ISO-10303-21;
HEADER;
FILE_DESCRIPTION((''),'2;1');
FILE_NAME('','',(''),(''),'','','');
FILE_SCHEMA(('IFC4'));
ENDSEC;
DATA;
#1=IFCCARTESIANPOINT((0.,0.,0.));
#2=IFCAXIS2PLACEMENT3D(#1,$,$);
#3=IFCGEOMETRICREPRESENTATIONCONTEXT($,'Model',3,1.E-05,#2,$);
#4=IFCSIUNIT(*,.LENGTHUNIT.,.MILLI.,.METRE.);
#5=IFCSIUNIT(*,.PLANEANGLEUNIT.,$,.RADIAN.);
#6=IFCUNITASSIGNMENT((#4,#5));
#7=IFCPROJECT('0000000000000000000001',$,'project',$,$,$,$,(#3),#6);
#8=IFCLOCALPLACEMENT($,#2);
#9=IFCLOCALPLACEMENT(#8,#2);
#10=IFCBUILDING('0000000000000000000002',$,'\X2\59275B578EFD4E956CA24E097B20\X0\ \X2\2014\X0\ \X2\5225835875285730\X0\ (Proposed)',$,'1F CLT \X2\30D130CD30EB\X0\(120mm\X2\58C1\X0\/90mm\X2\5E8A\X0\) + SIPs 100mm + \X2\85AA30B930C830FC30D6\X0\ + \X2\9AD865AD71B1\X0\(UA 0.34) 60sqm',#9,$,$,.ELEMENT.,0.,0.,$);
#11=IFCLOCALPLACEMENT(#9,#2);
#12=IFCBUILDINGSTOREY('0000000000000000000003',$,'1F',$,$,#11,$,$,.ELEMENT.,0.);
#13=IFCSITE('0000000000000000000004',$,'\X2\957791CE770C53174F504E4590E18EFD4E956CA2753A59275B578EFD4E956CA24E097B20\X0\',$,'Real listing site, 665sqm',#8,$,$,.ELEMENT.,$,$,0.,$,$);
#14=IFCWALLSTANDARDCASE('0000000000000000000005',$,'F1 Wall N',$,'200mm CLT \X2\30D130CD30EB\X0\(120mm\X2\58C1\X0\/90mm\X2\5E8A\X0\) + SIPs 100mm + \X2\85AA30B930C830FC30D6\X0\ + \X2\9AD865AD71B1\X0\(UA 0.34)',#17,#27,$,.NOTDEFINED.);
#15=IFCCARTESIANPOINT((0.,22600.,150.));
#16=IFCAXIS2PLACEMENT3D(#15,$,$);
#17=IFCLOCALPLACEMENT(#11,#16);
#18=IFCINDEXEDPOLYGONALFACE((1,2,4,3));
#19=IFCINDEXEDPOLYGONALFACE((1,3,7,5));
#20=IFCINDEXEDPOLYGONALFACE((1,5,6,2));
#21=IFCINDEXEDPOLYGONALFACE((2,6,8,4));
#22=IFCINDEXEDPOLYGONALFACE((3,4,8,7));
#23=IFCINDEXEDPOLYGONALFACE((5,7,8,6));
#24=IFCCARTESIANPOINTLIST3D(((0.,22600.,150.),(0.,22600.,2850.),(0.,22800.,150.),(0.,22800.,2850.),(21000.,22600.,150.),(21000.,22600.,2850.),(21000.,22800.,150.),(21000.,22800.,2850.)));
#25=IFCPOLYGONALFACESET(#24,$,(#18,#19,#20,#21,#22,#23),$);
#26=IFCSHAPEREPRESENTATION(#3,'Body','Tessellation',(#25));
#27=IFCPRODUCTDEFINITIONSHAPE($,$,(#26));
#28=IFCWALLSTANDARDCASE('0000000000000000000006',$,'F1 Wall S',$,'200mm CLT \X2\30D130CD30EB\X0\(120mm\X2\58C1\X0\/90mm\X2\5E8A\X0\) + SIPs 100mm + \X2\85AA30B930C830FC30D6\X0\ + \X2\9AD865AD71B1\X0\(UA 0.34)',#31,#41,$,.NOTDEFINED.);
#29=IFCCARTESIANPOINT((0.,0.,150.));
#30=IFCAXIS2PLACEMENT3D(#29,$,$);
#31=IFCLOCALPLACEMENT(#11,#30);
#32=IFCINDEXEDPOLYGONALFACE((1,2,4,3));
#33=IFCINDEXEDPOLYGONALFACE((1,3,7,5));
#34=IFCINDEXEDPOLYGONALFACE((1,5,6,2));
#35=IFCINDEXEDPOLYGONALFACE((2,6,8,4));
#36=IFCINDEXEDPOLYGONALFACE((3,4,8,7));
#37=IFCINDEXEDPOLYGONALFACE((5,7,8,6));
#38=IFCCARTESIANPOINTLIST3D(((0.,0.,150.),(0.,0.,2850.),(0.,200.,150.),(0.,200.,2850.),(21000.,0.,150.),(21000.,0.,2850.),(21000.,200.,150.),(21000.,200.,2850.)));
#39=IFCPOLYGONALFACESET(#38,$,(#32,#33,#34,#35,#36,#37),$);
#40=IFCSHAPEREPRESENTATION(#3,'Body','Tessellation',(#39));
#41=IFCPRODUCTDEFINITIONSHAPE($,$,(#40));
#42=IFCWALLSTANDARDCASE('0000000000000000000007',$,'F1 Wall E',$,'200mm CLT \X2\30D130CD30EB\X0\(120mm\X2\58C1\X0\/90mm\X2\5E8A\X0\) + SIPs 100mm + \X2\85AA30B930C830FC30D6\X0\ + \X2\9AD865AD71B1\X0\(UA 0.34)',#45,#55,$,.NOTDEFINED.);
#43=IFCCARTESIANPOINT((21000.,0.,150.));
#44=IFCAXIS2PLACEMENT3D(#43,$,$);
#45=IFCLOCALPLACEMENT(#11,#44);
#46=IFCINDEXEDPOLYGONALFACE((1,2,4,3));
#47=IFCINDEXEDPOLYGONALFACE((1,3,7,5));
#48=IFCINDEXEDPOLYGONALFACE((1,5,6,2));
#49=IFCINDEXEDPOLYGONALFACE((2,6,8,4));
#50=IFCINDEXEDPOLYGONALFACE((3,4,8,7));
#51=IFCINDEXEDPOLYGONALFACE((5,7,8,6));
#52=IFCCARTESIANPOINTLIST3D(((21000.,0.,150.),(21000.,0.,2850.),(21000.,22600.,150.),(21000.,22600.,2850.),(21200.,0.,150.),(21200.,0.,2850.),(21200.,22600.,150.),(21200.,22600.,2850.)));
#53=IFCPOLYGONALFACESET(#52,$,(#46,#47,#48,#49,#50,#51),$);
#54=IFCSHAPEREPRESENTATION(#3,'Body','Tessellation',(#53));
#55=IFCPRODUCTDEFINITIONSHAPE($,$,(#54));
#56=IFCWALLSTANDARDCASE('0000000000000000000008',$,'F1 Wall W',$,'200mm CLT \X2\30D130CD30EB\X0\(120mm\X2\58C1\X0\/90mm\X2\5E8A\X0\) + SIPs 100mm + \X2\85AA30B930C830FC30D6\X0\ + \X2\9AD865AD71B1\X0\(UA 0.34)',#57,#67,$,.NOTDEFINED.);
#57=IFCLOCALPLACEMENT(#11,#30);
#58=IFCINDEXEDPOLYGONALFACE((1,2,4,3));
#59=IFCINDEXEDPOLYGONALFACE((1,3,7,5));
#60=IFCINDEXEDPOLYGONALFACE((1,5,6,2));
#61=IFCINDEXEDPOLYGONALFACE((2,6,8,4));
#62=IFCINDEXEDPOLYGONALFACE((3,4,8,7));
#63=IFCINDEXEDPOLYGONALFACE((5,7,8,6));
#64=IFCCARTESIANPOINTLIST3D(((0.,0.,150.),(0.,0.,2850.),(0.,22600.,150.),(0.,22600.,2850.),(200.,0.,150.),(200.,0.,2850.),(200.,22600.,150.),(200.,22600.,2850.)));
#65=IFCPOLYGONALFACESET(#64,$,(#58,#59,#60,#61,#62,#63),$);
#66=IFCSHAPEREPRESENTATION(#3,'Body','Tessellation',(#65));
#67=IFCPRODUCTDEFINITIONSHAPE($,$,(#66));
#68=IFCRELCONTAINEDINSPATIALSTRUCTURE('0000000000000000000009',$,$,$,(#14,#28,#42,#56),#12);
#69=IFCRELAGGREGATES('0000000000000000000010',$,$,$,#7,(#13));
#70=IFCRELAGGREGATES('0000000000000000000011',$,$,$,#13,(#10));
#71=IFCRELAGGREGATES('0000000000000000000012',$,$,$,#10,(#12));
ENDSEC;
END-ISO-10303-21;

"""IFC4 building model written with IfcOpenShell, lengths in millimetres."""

from ifc_helpers import new_model, si_unit, frame, frame_2d, origin, place, context, project, spatial, rectangle, extrude, element, save


model = new_model("IFC4")

# Units and contexts
model_context = context("Model", 3, precision=1e-05, world=origin())
ifc_project = project(units=[si_unit("LENGTHUNIT", "METRE", prefix="MILLI"), si_unit("PLANEANGLEUNIT", "RADIAN")], contexts=[model_context])

# Site, building, storey
site_placement = place(None, origin())
site = spatial("IfcSite", under=ifc_project, at=site_placement, Name="長野県北佐久郡軽井沢町大字軽井沢三笠", ObjectType="Real listing site, 665sqm", CompositionType="ELEMENT", RefElevation=0.0)
building_placement = place(site_placement, origin())
building = spatial("IfcBuilding", under=site, at=building_placement, Name="大字軽井沢三笠 — 別荘用地 (Proposed)", ObjectType="1F CLT パネル(120mm壁/90mm床) + SIPs 100mm + 薪ストーブ + 高断熱(UA 0.34) 60sqm", CompositionType="ELEMENT", ElevationOfRefHeight=0.0, ElevationOfTerrain=0.0)
storey_placement = place(building_placement, origin())
storey = spatial("IfcBuildingStorey", under=building, at=storey_placement, Name="1F", CompositionType="ELEMENT", Elevation=0.0)

# Walls
wall_1_placement = place(storey_placement, frame((0.0, 22600.0, 150.0)))
element("IfcWallStandardCase", 1, at=wall_1_placement, inside=storey, Name="F1 Wall N", ObjectType="200mm CLT パネル(120mm壁/90mm床) + SIPs 100mm + 薪ストーブ + 高断熱(UA 0.34)", PredefinedType="NOTDEFINED", context=model_context, shape_type="SweptSolid", body=[
    extrude(rectangle(XDim=21000.0, YDim=200.0, at=frame_2d((10500.0, 100.0))), frame((0.0, 22600.0, 150.0)), (0.0, 0.0, 1.0), 2700.0),
])
wall_2_placement = place(storey_placement, frame((0.0, 0.0, 150.0)))
element("IfcWallStandardCase", 2, at=wall_2_placement, inside=storey, Name="F1 Wall S", ObjectType="200mm CLT パネル(120mm壁/90mm床) + SIPs 100mm + 薪ストーブ + 高断熱(UA 0.34)", PredefinedType="NOTDEFINED", context=model_context, shape_type="SweptSolid", body=[
    extrude(rectangle(XDim=21000.0, YDim=200.0, at=frame_2d((10500.0, 100.0))), frame((0.0, 0.0, 150.0)), (0.0, 0.0, 1.0), 2700.0),
])
wall_3_placement = place(storey_placement, frame((21000.0, 0.0, 150.0)))
element("IfcWallStandardCase", 3, at=wall_3_placement, inside=storey, Name="F1 Wall E", ObjectType="200mm CLT パネル(120mm壁/90mm床) + SIPs 100mm + 薪ストーブ + 高断熱(UA 0.34)", PredefinedType="NOTDEFINED", context=model_context, shape_type="SweptSolid", body=[
    extrude(rectangle(XDim=200.0, YDim=22600.0, at=frame_2d((100.0, 11300.0))), frame((21000.0, 0.0, 150.0)), (0.0, 0.0, 1.0), 2700.0),
])
wall_4_placement = place(storey_placement, frame((0.0, 0.0, 150.0)))
element("IfcWallStandardCase", 4, at=wall_4_placement, inside=storey, Name="F1 Wall W", ObjectType="200mm CLT パネル(120mm壁/90mm床) + SIPs 100mm + 薪ストーブ + 高断熱(UA 0.34)", PredefinedType="NOTDEFINED", context=model_context, shape_type="SweptSolid", body=[
    extrude(rectangle(XDim=200.0, YDim=22600.0, at=frame_2d((100.0, 11300.0))), frame((0.0, 0.0, 150.0)), (0.0, 0.0, 1.0), 2700.0),
])

save(model, "model.ifc")
